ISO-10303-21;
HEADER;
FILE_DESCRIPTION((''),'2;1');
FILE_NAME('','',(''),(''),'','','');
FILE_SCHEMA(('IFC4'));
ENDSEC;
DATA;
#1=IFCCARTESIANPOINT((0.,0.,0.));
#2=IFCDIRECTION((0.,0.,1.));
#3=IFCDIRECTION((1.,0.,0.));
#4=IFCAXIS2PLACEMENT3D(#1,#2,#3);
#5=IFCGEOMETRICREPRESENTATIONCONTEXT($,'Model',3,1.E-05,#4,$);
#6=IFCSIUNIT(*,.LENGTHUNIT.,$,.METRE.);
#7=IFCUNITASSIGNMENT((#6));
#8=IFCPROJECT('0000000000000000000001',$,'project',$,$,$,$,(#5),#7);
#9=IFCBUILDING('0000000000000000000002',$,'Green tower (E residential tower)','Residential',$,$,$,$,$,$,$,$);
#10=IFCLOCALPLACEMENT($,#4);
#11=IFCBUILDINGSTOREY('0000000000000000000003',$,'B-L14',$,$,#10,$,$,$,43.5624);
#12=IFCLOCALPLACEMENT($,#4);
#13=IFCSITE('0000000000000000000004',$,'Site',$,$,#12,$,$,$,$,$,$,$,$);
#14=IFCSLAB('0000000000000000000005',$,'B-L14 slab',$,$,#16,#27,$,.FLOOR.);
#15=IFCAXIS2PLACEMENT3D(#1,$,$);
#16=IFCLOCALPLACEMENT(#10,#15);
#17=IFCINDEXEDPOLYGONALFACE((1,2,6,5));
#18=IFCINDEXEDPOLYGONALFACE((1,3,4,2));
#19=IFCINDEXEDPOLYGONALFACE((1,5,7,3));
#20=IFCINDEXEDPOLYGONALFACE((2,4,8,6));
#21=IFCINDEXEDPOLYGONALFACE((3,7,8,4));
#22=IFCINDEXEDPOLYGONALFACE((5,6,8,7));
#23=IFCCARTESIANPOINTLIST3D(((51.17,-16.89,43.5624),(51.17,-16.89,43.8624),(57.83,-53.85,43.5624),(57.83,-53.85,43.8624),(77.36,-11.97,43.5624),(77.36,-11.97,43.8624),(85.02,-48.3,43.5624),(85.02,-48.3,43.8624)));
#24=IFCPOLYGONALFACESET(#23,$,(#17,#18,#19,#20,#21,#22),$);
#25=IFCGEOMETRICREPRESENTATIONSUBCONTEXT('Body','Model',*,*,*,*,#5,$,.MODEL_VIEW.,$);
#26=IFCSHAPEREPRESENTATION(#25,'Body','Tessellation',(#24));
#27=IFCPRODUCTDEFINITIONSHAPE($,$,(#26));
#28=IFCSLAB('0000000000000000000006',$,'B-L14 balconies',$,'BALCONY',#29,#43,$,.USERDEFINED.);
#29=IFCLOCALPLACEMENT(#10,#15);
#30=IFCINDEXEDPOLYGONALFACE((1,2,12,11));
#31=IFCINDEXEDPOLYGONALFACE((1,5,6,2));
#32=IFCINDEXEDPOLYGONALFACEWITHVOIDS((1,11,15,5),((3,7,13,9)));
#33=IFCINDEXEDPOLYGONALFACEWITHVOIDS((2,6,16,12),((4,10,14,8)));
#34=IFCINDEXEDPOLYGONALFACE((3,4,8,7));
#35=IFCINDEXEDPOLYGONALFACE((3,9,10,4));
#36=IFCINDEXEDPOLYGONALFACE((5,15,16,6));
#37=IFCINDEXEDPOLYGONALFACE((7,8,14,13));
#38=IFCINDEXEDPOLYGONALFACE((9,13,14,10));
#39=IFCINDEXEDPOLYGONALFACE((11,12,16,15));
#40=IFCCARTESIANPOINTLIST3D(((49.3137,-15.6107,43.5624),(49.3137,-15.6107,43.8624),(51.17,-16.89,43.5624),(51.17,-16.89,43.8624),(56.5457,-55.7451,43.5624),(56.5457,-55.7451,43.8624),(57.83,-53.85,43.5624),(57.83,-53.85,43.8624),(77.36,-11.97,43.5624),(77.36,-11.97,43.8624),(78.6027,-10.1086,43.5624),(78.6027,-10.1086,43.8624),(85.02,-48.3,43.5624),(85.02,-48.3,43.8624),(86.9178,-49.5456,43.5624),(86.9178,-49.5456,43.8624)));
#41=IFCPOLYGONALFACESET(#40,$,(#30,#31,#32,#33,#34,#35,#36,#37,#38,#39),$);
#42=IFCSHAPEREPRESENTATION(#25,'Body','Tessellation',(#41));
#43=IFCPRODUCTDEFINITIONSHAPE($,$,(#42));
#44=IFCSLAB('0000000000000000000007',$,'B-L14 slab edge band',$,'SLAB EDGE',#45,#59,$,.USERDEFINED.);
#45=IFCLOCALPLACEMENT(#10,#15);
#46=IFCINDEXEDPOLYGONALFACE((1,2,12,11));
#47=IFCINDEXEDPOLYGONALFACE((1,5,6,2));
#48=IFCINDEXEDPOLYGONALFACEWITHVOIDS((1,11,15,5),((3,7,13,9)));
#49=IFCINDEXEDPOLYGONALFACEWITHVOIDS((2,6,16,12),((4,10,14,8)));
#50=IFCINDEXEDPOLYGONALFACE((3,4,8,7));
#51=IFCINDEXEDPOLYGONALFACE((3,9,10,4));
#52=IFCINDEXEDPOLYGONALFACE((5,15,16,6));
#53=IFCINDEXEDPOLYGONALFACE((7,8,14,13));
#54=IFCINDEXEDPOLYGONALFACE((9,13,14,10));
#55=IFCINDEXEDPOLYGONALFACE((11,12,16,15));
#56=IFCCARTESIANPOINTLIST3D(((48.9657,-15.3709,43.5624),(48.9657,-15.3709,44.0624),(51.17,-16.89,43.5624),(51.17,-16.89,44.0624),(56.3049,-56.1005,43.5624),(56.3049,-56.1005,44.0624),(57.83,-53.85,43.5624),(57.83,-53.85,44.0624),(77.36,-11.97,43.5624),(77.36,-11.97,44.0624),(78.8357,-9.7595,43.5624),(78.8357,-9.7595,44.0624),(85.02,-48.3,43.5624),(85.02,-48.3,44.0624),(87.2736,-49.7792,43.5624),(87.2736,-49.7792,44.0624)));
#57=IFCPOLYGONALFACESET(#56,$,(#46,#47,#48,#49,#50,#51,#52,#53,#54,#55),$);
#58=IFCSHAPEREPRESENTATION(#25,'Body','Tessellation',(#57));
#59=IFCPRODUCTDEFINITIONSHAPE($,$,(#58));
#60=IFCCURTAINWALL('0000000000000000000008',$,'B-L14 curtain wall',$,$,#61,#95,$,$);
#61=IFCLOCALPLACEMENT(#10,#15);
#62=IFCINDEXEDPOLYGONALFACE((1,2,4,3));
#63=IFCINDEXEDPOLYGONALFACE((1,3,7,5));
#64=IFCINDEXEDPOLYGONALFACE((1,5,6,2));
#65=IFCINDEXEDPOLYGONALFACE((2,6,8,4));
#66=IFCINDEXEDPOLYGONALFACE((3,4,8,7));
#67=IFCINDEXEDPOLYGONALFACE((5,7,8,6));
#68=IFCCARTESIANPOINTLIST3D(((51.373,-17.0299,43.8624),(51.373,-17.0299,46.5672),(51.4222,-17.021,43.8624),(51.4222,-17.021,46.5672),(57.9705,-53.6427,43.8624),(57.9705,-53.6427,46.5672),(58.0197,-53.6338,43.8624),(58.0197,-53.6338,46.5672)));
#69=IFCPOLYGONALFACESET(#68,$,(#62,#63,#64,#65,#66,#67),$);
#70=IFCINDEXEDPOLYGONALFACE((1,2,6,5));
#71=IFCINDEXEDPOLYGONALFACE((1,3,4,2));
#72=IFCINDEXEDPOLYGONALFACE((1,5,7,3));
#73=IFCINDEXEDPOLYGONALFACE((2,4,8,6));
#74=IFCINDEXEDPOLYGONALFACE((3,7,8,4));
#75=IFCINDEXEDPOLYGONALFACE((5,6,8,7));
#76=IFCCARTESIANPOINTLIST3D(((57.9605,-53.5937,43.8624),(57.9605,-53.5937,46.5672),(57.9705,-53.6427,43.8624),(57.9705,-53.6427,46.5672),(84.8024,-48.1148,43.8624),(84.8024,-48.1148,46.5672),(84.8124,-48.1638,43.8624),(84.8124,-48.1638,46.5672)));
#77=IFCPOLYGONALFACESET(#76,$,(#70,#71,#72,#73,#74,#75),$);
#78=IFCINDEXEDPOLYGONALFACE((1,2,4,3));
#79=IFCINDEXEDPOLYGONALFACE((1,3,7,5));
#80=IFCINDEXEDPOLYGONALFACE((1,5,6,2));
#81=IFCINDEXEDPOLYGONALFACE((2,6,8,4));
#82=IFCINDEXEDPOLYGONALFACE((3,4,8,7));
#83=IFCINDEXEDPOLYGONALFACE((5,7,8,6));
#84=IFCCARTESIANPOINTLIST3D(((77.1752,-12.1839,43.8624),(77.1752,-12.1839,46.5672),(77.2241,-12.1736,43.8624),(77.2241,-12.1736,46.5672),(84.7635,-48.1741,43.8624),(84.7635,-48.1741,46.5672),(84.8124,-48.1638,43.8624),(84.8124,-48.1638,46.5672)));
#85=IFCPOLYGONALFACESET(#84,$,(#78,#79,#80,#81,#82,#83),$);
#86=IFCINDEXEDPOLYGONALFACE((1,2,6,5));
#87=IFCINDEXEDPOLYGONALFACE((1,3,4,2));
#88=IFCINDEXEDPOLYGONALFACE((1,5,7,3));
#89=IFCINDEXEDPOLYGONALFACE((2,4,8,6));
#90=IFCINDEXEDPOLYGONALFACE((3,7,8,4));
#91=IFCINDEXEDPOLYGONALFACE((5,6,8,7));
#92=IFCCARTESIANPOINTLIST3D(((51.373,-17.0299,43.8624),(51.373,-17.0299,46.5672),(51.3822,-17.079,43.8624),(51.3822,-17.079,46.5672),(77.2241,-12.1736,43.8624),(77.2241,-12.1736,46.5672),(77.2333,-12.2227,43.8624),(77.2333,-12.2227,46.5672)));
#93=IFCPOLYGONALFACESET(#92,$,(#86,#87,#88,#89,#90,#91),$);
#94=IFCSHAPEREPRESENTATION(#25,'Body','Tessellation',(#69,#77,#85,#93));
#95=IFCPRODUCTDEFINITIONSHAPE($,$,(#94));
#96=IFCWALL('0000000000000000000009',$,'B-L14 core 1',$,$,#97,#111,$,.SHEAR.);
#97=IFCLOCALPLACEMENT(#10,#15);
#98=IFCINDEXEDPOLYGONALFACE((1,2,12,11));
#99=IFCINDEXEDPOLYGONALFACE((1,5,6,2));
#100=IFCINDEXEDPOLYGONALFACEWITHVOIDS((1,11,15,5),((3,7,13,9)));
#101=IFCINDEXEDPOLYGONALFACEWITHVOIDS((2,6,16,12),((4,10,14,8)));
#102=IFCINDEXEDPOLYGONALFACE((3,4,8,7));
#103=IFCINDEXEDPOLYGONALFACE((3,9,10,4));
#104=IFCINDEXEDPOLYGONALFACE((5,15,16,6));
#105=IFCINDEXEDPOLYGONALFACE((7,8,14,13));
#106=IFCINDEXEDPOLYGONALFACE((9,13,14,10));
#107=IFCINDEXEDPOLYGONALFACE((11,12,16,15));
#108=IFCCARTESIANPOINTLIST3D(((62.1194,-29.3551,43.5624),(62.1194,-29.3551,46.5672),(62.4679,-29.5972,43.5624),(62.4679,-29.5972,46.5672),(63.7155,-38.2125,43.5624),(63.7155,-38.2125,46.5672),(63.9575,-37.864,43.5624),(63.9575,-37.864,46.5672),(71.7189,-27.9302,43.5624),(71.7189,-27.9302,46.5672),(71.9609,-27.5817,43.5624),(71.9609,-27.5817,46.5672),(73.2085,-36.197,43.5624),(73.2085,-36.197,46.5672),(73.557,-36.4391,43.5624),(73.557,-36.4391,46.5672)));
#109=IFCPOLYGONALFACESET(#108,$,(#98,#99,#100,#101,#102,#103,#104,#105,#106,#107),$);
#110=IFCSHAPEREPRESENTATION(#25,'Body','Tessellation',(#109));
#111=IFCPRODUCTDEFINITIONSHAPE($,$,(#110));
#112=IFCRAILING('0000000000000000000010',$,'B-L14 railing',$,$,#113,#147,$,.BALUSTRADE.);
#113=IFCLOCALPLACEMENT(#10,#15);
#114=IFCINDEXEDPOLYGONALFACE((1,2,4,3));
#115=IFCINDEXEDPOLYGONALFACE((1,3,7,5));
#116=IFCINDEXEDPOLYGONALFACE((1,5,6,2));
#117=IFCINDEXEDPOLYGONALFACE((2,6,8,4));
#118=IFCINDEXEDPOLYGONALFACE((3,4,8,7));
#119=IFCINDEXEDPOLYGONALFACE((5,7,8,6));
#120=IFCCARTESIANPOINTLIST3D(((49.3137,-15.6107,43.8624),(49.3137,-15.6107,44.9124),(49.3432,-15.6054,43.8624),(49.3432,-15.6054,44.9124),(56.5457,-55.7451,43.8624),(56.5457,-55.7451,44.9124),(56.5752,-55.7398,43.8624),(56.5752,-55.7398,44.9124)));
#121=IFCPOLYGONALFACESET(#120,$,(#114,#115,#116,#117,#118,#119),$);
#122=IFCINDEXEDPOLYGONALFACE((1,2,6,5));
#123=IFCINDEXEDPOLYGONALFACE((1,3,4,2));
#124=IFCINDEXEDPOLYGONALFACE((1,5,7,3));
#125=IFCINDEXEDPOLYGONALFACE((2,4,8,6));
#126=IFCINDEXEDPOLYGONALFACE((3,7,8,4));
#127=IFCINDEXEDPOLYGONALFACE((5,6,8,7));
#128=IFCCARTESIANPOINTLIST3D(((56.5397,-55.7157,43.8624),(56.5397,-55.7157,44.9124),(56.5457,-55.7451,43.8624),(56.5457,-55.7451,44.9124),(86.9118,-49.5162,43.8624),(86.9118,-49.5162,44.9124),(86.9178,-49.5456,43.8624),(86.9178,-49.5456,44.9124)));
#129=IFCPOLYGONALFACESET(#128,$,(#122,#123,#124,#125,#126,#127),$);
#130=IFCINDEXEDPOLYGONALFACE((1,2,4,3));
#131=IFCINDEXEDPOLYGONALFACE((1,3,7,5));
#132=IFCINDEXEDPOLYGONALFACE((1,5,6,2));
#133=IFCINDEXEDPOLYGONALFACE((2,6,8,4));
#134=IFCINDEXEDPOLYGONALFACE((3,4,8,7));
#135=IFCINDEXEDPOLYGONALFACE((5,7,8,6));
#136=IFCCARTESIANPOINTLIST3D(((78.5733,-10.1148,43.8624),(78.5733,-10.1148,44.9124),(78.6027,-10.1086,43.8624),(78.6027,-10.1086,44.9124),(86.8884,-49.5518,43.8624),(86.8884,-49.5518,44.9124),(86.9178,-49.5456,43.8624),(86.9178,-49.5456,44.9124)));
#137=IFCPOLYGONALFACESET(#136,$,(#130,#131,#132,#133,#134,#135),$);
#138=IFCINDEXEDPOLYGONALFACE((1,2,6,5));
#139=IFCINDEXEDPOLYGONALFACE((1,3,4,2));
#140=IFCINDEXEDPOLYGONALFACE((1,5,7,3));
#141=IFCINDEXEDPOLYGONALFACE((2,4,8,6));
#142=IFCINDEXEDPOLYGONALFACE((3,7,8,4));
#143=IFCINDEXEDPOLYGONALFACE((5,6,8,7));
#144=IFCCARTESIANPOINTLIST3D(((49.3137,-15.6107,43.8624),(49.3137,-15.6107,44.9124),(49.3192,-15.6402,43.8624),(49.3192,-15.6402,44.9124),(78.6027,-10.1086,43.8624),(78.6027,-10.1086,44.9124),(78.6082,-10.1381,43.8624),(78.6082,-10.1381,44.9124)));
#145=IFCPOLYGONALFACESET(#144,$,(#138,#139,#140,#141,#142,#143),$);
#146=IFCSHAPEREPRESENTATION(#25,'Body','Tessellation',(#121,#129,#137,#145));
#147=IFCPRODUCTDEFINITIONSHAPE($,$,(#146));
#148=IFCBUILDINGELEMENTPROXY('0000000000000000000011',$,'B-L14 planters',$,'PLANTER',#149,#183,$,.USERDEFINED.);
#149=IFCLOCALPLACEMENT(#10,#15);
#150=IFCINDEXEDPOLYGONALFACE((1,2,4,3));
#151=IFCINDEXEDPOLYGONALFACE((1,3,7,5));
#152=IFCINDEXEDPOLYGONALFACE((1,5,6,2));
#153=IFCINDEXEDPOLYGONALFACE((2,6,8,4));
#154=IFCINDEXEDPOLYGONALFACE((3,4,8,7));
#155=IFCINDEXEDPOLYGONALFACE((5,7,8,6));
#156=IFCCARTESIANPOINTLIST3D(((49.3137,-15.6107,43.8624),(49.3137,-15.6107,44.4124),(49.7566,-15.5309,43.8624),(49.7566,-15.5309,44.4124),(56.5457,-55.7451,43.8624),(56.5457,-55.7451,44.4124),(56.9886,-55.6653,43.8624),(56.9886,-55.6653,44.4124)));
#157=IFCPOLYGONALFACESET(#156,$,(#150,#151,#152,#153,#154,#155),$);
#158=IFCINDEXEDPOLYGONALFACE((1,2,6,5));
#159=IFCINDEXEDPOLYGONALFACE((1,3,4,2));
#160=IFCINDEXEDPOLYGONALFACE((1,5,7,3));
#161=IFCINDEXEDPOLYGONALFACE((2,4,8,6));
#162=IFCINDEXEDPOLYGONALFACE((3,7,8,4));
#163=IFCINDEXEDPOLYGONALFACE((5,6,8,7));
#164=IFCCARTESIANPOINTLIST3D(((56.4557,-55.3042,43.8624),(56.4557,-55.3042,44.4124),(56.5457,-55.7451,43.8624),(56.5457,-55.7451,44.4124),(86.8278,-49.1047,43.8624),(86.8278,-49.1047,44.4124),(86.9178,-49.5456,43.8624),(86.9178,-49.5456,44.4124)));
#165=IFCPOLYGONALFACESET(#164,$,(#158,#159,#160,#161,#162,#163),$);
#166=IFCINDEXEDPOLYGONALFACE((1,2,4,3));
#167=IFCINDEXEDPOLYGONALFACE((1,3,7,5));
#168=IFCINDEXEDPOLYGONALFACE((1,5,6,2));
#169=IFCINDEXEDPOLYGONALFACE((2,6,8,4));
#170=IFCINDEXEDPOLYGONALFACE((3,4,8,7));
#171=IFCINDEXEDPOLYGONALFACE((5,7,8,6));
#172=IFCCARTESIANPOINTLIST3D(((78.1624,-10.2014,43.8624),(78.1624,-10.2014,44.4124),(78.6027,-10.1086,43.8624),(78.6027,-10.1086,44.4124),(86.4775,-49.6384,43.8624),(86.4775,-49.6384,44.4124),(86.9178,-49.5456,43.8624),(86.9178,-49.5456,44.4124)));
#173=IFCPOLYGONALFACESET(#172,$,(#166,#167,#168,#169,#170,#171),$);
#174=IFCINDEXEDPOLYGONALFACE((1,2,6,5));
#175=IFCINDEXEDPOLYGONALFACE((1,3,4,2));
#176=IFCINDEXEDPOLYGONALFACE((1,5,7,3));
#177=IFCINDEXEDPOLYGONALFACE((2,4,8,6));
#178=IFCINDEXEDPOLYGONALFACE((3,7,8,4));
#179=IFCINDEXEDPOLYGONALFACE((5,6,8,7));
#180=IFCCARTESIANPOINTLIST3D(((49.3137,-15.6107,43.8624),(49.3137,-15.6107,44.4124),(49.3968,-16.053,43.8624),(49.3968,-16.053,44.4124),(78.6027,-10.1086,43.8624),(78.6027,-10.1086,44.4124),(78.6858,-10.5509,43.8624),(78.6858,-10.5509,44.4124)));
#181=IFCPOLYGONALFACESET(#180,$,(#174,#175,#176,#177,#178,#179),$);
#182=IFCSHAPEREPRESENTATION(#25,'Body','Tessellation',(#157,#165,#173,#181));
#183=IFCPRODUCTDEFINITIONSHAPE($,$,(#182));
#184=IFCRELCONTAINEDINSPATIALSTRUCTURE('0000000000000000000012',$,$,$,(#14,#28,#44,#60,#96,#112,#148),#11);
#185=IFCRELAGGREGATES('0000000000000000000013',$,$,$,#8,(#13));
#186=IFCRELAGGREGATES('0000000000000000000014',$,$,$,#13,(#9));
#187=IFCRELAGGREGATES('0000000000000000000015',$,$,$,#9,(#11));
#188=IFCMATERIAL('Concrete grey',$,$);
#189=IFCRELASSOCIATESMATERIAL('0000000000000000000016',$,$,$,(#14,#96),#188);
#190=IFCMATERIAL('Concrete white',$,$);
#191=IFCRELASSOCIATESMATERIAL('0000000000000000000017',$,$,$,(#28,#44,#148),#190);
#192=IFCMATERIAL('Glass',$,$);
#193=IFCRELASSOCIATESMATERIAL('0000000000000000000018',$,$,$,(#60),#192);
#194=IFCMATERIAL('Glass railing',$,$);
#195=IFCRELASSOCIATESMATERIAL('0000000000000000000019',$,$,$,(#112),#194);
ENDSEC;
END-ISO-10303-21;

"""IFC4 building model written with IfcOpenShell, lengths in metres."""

from ifc_helpers import new_model, si_unit, frame, origin_with_axes, place, context, subcontext, project, spatial, polyline, outline, extrude, material, element, save


model = new_model("IFC4")

# Units and contexts
model_context = context("Model", 3, precision=1e-05, world=origin_with_axes())
body_context = subcontext(model_context, "Body", "Model", "MODEL_VIEW")
ifc_project = project(units=[si_unit("LENGTHUNIT", "METRE")], contexts=[model_context])

# Site, building, storey
site_placement = place(None, origin_with_axes())
site = spatial("IfcSite", under=ifc_project, at=site_placement, Name="Site")
building = spatial("IfcBuilding", under=site, Name="Green tower (E residential tower)", Description="Residential")
storey_placement = place(None, origin_with_axes())
storey = spatial("IfcBuildingStorey", under=building, at=storey_placement, Name="B-L14", Elevation=43.5624)

# Slabs
ifc_material_1 = material(Name="Concrete grey")
slab_1_placement = place(storey_placement, origin_with_axes())
element("IfcSlab", 1, at=slab_1_placement, inside=storey, material=ifc_material_1, Name="B-L14 slab", PredefinedType="FLOOR", context=body_context, shape_type="SweptSolid", body=[
    extrude(outline(polyline([(51.17, -16.89), (57.83, -53.85), (85.02, -48.3), (77.36, -11.97), (51.17, -16.89)])), frame((0.0, 0.0, 43.5624), z_axis=(0.0, 0.0, 1.0), x_axis=(1.0, 0.0, 0.0)), (0.0, 0.0, 1.0), 0.3),
])
ifc_material_2 = material(Name="Concrete white")
slab_2_placement = place(storey_placement, origin_with_axes())
element("IfcSlab", 2, at=slab_2_placement, inside=storey, material=ifc_material_2, Name="B-L14 balconies", ObjectType="BALCONY", PredefinedType="USERDEFINED", context=body_context, shape_type="SweptSolid", body=[
    extrude(outline(polyline([(49.3137, -15.6107), (56.5457, -55.7451), (86.9178, -49.5456), (78.6027, -10.1086), (49.3137, -15.6107)]), holes=[polyline([(51.17, -16.89), (57.83, -53.85), (85.02, -48.3), (77.36, -11.97), (51.17, -16.89)])]), frame((0.0, 0.0, 43.5624), z_axis=(0.0, 0.0, 1.0), x_axis=(1.0, 0.0, 0.0)), (0.0, 0.0, 1.0), 0.3),
])
slab_3_placement = place(storey_placement, origin_with_axes())
element("IfcSlab", 3, at=slab_3_placement, inside=storey, material=ifc_material_2, Name="B-L14 slab edge band", ObjectType="SLAB EDGE", PredefinedType="USERDEFINED", context=body_context, shape_type="SweptSolid", body=[
    extrude(outline(polyline([(48.9657, -15.3709), (56.3049, -56.1005), (87.2736, -49.7792), (78.8357, -9.7595), (48.9657, -15.3709)]), holes=[polyline([(51.17, -16.89), (57.83, -53.85), (85.02, -48.3), (77.36, -11.97), (51.17, -16.89)])]), frame((0.0, 0.0, 43.5624), z_axis=(0.0, 0.0, 1.0), x_axis=(1.0, 0.0, 0.0)), (0.0, 0.0, 1.0), 0.5),
])

# Curtain wall
ifc_material_3 = material(Name="Glass")
curtain_wall_placement = place(storey_placement, origin_with_axes())
element("IfcCurtainWall", 4, at=curtain_wall_placement, inside=storey, material=ifc_material_3, Name="B-L14 curtain wall", context=body_context, shape_type="SweptSolid", body=[
    extrude(outline(polyline([(51.373, -17.0299), (57.9705, -53.6427), (58.0197, -53.6338), (51.4222, -17.021), (51.373, -17.0299)])), frame((0.0, 0.0, 43.8624), z_axis=(0.0, 0.0, 1.0), x_axis=(1.0, 0.0, 0.0)), (0.0, 0.0, 1.0), 2.7048),
    extrude(outline(polyline([(57.9705, -53.6427), (84.8124, -48.1638), (84.8024, -48.1148), (57.9605, -53.5937), (57.9705, -53.6427)])), frame((0.0, 0.0, 43.8624), z_axis=(0.0, 0.0, 1.0), x_axis=(1.0, 0.0, 0.0)), (0.0, 0.0, 1.0), 2.7048),
    extrude(outline(polyline([(84.8124, -48.1638), (77.2241, -12.1736), (77.1752, -12.1839), (84.7635, -48.1741), (84.8124, -48.1638)])), frame((0.0, 0.0, 43.8624), z_axis=(0.0, 0.0, 1.0), x_axis=(1.0, 0.0, 0.0)), (0.0, 0.0, 1.0), 2.7048),
    extrude(outline(polyline([(77.2241, -12.1736), (51.373, -17.0299), (51.3822, -17.079), (77.2333, -12.2227), (77.2241, -12.1736)])), frame((0.0, 0.0, 43.8624), z_axis=(0.0, 0.0, 1.0), x_axis=(1.0, 0.0, 0.0)), (0.0, 0.0, 1.0), 2.7048),
])

# Wall
wall_placement = place(storey_placement, origin_with_axes())
element("IfcWall", 5, at=wall_placement, inside=storey, material=ifc_material_1, Name="B-L14 core 1", PredefinedType="SHEAR", context=body_context, shape_type="SweptSolid", body=[
    extrude(outline(polyline([(62.1194, -29.3551), (63.7155, -38.2125), (73.557, -36.4391), (71.9609, -27.5817), (62.1194, -29.3551)]), holes=[polyline([(62.4679, -29.5972), (63.9575, -37.864), (73.2085, -36.197), (71.7189, -27.9302), (62.4679, -29.5972)])]), frame((0.0, 0.0, 43.5624), z_axis=(0.0, 0.0, 1.0), x_axis=(1.0, 0.0, 0.0)), (0.0, 0.0, 1.0), 3.0048),
])

# Railing
ifc_material_4 = material(Name="Glass railing")
railing_placement = place(storey_placement, origin_with_axes())
element("IfcRailing", 6, at=railing_placement, inside=storey, material=ifc_material_4, Name="B-L14 railing", PredefinedType="BALUSTRADE", context=body_context, shape_type="SweptSolid", body=[
    extrude(outline(polyline([(49.3137, -15.6107), (56.5457, -55.7451), (56.5752, -55.7398), (49.3432, -15.6054), (49.3137, -15.6107)])), frame((0.0, 0.0, 43.8624), z_axis=(0.0, 0.0, 1.0), x_axis=(1.0, 0.0, 0.0)), (0.0, 0.0, 1.0), 1.05),
    extrude(outline(polyline([(56.5457, -55.7451), (86.9178, -49.5456), (86.9118, -49.5162), (56.5397, -55.7157), (56.5457, -55.7451)])), frame((0.0, 0.0, 43.8624), z_axis=(0.0, 0.0, 1.0), x_axis=(1.0, 0.0, 0.0)), (0.0, 0.0, 1.0), 1.05),
    extrude(outline(polyline([(86.9178, -49.5456), (78.6027, -10.1086), (78.5733, -10.1148), (86.8884, -49.5518), (86.9178, -49.5456)])), frame((0.0, 0.0, 43.8624), z_axis=(0.0, 0.0, 1.0), x_axis=(1.0, 0.0, 0.0)), (0.0, 0.0, 1.0), 1.05),
    extrude(outline(polyline([(78.6027, -10.1086), (49.3137, -15.6107), (49.3192, -15.6402), (78.6082, -10.1381), (78.6027, -10.1086)])), frame((0.0, 0.0, 43.8624), z_axis=(0.0, 0.0, 1.0), x_axis=(1.0, 0.0, 0.0)), (0.0, 0.0, 1.0), 1.05),
])

# Building element proxy
proxy_1_placement = place(storey_placement, origin_with_axes())
element("IfcBuildingElementProxy", 7, at=proxy_1_placement, inside=storey, material=ifc_material_2, Name="B-L14 planters", ObjectType="PLANTER", PredefinedType="USERDEFINED", context=body_context, shape_type="SweptSolid", body=[
    extrude(outline(polyline([(49.3137, -15.6107), (56.5457, -55.7451), (56.9886, -55.6653), (49.7566, -15.5309), (49.3137, -15.6107)])), frame((0.0, 0.0, 43.8624), z_axis=(0.0, 0.0, 1.0), x_axis=(1.0, 0.0, 0.0)), (0.0, 0.0, 1.0), 0.55),
    extrude(outline(polyline([(56.5457, -55.7451), (86.9178, -49.5456), (86.8278, -49.1047), (56.4557, -55.3042), (56.5457, -55.7451)])), frame((0.0, 0.0, 43.8624), z_axis=(0.0, 0.0, 1.0), x_axis=(1.0, 0.0, 0.0)), (0.0, 0.0, 1.0), 0.55),
    extrude(outline(polyline([(86.9178, -49.5456), (78.6027, -10.1086), (78.1624, -10.2014), (86.4775, -49.6384), (86.9178, -49.5456)])), frame((0.0, 0.0, 43.8624), z_axis=(0.0, 0.0, 1.0), x_axis=(1.0, 0.0, 0.0)), (0.0, 0.0, 1.0), 0.55),
    extrude(outline(polyline([(78.6027, -10.1086), (49.3137, -15.6107), (49.3968, -16.053), (78.6858, -10.5509), (78.6027, -10.1086)])), frame((0.0, 0.0, 43.8624), z_axis=(0.0, 0.0, 1.0), x_axis=(1.0, 0.0, 0.0)), (0.0, 0.0, 1.0), 0.55),
])

save(model, "model.ifc")
